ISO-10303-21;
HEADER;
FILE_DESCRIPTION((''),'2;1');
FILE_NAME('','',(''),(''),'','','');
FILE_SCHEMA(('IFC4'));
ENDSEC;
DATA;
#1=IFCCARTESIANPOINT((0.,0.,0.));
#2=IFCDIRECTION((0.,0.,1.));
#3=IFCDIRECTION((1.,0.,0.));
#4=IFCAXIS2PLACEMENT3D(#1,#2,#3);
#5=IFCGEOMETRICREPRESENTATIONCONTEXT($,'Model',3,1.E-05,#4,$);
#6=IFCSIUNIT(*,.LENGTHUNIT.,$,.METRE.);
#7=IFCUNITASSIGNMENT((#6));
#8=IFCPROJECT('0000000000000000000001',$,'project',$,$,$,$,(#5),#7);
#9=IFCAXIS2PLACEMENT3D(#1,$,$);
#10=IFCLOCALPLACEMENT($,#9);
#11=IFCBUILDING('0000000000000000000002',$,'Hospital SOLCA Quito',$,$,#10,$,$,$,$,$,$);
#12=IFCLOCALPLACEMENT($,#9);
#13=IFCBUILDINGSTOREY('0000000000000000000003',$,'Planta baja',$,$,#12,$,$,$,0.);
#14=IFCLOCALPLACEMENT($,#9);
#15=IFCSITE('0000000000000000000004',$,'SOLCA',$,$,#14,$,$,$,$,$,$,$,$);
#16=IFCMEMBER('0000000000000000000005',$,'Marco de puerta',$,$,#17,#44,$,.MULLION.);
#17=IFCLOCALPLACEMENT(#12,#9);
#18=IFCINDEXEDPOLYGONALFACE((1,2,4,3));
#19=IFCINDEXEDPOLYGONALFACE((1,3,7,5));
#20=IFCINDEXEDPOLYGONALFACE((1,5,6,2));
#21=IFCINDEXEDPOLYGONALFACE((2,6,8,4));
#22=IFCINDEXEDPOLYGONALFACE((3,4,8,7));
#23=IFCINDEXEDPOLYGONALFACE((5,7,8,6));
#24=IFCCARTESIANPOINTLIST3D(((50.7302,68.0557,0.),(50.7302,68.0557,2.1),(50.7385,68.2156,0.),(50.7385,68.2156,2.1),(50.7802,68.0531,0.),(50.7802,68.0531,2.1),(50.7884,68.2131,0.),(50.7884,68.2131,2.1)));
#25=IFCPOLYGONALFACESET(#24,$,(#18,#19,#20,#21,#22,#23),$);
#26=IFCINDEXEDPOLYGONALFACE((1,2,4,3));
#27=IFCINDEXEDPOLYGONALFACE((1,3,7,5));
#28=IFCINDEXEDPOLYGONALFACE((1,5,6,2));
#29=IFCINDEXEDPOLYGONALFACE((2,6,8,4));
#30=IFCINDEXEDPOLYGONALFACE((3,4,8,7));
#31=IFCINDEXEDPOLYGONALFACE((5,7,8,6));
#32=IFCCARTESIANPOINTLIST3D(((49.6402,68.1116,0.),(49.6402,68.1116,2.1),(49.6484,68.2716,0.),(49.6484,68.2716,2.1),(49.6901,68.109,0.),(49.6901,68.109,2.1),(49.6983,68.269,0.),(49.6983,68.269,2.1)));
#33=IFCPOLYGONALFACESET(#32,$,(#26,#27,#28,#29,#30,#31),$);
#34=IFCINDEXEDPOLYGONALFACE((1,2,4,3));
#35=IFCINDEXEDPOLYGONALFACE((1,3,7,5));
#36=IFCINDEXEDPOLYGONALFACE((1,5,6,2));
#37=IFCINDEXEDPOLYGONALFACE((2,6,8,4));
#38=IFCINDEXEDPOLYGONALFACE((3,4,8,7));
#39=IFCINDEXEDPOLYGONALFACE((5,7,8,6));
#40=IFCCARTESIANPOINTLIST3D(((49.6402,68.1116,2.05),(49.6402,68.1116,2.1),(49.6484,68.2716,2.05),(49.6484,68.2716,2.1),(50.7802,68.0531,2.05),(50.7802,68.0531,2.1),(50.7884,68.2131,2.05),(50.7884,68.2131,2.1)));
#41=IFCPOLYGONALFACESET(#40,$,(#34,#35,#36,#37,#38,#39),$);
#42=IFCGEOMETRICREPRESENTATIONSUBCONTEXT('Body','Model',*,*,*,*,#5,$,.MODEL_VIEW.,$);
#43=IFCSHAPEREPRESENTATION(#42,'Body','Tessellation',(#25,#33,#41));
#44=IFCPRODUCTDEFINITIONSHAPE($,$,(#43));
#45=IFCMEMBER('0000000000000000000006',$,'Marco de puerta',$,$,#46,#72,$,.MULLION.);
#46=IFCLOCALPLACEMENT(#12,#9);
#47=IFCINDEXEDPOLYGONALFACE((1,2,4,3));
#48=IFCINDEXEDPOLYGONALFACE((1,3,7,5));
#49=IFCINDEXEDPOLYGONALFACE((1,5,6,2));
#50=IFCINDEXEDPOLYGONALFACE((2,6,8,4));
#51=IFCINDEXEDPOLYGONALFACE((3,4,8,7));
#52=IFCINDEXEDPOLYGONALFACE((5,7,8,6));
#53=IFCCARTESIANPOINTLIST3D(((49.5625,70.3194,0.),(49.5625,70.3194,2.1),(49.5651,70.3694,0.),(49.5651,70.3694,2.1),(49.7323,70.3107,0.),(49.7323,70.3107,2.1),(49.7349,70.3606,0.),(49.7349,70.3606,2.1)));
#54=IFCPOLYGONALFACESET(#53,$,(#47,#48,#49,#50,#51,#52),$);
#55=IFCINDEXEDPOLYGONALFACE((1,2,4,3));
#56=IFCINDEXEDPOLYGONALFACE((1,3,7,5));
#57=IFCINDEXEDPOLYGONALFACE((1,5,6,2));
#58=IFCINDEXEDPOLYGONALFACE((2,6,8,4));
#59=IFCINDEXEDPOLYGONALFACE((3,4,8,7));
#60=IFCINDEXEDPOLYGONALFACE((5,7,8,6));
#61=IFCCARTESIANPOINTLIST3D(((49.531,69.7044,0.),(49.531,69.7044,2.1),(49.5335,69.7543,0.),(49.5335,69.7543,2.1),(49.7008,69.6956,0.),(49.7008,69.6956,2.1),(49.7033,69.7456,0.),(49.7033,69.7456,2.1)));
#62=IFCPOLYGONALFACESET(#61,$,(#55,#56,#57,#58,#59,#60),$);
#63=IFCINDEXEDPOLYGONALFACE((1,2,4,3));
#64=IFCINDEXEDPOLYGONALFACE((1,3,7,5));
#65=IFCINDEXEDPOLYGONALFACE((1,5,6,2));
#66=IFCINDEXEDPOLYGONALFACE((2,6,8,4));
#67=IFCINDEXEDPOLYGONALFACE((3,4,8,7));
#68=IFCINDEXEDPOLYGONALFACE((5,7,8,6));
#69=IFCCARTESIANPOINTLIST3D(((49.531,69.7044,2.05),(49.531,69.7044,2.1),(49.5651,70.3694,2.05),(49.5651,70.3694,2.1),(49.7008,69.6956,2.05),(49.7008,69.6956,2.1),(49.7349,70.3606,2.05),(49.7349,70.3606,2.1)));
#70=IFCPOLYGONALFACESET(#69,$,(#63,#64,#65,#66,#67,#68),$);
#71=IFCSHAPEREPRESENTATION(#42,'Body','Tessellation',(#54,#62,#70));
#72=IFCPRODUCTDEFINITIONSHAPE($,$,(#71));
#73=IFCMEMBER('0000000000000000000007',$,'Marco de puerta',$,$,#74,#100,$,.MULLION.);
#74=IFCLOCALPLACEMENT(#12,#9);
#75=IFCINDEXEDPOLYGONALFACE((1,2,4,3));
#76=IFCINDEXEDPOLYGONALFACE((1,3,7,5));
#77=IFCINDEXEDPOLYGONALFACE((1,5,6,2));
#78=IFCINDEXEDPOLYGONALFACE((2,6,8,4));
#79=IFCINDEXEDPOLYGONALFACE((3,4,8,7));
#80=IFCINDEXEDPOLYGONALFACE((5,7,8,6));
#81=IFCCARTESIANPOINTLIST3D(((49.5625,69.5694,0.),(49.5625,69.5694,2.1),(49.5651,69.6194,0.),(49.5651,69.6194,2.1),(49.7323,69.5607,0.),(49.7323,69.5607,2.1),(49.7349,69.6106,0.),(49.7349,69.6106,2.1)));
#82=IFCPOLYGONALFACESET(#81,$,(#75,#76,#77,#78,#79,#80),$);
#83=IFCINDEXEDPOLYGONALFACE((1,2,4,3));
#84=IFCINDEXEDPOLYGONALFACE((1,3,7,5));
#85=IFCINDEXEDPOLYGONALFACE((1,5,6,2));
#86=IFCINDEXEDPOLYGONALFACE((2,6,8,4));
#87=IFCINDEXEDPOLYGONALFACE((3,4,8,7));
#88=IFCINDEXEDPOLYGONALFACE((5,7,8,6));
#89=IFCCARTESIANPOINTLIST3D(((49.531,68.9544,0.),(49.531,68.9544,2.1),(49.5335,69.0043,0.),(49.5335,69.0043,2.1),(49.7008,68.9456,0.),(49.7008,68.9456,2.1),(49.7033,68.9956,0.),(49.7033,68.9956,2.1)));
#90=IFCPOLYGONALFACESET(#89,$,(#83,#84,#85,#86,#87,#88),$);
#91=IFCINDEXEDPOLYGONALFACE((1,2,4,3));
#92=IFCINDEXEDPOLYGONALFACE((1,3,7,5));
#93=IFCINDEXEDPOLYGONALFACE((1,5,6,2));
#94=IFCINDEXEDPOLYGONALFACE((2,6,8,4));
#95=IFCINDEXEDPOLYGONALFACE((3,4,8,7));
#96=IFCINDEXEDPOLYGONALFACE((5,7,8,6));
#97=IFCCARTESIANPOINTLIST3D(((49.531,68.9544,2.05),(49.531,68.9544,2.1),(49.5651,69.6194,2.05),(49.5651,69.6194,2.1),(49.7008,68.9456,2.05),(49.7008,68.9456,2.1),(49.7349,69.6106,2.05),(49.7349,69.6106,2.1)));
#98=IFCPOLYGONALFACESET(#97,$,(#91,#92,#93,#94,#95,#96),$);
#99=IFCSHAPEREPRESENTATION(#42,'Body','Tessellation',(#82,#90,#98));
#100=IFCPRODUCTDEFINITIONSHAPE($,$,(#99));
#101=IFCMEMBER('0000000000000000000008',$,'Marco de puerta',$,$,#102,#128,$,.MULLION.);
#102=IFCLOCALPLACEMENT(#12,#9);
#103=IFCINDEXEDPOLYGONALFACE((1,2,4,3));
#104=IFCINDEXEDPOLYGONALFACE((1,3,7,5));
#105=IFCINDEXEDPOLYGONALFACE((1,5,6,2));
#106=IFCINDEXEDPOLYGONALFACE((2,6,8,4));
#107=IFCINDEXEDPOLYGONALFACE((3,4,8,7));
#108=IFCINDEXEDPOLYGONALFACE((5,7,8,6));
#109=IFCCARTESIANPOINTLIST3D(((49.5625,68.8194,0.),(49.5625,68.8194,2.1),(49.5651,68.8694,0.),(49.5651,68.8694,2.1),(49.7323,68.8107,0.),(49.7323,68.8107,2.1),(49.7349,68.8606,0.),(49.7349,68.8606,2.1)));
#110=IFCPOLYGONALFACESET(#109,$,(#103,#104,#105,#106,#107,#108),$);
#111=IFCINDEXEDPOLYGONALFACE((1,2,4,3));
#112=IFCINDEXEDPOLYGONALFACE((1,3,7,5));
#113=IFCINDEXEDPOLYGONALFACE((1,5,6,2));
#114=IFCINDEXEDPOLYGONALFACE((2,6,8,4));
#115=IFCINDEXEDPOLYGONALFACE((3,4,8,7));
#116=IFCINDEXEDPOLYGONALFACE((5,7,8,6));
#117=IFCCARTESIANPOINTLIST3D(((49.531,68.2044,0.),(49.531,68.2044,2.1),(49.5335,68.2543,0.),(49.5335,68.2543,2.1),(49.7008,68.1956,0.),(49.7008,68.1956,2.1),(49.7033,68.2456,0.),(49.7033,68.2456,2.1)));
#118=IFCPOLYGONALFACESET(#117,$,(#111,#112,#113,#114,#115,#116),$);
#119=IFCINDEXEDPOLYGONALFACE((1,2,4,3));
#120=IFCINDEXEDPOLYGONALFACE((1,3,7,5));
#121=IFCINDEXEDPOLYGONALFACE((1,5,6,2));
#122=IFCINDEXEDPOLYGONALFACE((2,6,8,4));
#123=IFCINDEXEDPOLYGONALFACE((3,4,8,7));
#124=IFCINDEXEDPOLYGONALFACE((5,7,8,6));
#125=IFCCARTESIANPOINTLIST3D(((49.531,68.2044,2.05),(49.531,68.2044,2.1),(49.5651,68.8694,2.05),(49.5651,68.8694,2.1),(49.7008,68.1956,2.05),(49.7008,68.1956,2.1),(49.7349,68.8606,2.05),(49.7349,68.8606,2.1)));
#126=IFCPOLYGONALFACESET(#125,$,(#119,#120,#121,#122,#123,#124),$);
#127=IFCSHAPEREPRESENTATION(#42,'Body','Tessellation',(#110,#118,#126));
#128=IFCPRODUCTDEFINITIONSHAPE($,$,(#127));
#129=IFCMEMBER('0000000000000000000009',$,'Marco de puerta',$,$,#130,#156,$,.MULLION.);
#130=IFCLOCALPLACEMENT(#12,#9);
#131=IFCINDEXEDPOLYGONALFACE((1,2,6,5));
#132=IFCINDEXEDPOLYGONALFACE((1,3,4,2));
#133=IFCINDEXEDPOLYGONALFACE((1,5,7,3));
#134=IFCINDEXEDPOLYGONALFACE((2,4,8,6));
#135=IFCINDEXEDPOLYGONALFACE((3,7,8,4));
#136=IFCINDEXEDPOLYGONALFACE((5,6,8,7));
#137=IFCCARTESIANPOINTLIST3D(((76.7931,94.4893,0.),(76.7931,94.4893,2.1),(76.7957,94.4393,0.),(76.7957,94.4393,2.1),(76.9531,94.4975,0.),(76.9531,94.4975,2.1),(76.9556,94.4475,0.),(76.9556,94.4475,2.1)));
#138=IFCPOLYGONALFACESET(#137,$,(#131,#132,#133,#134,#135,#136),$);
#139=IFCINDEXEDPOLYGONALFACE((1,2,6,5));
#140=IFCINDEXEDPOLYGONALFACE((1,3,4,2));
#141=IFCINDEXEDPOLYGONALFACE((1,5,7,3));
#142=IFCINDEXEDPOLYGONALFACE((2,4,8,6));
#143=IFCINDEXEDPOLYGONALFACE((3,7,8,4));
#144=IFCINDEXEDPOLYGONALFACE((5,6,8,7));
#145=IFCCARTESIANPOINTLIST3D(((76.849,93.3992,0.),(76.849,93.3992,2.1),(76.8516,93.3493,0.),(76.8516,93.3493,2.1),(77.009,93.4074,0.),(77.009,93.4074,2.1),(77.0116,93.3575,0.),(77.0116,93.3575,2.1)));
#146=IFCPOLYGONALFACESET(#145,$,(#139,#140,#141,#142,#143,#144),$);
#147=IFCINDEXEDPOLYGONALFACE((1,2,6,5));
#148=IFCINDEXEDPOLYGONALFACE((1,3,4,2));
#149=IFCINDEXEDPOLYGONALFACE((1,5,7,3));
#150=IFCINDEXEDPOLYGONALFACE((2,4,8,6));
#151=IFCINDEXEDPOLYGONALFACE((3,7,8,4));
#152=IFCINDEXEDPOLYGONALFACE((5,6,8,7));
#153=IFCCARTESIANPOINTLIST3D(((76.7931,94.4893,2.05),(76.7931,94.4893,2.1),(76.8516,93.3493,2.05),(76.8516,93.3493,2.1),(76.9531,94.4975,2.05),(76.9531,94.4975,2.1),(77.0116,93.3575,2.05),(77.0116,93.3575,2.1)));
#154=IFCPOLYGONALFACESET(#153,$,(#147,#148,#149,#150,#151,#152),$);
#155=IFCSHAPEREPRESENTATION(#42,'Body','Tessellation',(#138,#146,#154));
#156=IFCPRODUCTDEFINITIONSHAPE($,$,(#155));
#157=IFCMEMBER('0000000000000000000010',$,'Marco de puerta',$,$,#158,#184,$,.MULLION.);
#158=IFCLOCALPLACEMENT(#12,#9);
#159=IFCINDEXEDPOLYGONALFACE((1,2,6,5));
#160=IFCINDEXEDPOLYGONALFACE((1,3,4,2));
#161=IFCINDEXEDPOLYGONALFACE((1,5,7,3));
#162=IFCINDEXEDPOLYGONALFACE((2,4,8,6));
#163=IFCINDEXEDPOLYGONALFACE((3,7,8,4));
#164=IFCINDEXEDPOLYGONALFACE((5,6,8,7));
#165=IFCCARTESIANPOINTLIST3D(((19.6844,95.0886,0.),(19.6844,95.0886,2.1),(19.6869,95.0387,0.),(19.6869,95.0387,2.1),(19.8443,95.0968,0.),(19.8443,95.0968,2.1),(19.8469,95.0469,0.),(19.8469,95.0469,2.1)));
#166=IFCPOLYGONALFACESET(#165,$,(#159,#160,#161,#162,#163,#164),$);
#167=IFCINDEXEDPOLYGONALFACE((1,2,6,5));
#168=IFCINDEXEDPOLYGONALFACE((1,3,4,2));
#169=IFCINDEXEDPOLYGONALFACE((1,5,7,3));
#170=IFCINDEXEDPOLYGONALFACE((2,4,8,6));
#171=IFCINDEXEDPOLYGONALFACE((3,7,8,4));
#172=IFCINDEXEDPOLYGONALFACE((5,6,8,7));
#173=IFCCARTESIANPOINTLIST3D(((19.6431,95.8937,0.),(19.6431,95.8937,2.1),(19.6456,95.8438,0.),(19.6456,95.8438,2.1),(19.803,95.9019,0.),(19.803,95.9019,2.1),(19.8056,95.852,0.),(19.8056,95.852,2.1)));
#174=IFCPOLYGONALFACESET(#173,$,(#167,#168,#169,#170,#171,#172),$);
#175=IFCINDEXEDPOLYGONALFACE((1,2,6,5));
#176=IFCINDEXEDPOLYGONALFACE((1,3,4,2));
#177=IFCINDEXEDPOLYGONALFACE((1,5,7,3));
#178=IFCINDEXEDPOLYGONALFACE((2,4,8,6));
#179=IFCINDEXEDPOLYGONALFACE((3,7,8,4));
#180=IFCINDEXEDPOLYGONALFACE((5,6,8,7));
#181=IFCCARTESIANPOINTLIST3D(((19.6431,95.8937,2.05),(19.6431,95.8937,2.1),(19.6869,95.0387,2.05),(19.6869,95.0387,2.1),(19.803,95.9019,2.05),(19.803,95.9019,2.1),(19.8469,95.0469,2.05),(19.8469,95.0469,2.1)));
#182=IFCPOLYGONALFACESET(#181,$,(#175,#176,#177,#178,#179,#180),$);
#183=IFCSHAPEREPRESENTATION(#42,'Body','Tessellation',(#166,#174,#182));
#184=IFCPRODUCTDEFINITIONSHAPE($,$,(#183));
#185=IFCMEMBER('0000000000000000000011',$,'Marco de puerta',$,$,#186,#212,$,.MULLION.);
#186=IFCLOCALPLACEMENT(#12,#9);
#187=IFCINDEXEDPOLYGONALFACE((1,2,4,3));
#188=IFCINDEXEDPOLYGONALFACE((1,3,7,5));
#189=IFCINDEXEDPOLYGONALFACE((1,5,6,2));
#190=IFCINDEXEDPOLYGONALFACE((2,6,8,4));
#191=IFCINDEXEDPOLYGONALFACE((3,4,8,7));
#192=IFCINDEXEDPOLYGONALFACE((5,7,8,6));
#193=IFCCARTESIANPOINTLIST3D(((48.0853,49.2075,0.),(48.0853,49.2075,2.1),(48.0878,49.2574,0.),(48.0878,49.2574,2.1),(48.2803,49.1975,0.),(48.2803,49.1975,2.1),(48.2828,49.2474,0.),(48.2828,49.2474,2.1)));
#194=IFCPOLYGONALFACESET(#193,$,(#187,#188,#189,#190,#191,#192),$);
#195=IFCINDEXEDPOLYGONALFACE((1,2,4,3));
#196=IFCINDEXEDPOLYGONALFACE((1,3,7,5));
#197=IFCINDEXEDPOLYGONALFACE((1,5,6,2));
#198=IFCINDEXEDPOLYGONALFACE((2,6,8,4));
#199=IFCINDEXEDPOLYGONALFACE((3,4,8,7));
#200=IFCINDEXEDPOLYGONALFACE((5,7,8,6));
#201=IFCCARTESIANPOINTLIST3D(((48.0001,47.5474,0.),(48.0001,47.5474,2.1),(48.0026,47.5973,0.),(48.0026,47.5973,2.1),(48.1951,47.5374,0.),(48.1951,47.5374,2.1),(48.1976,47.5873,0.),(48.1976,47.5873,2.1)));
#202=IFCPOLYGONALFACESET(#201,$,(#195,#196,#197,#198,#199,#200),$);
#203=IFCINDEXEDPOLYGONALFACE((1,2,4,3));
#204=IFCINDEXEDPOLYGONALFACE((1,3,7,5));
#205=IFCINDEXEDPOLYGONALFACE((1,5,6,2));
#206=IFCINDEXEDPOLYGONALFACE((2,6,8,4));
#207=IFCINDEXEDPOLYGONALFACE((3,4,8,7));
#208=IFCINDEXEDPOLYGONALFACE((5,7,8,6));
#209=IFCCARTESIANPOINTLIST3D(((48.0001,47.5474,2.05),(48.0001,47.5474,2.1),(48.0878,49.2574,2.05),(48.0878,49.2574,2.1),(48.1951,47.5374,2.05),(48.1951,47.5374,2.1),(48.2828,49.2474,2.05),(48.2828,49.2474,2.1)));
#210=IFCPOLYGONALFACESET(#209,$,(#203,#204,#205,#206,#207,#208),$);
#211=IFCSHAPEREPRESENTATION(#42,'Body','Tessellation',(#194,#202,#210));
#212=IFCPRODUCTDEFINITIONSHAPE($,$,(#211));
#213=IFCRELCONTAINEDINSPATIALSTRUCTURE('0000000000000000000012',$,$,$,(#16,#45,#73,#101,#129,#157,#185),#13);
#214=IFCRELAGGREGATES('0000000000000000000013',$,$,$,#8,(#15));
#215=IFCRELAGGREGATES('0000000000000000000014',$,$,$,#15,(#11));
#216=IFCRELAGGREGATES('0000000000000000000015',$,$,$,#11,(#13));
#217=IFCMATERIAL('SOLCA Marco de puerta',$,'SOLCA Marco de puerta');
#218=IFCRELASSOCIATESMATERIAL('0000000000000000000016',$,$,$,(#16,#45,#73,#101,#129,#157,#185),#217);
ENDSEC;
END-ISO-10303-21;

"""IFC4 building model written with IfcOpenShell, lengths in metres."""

from ifc_helpers import new_model, si_unit, frame, origin, origin_with_axes, place, context, subcontext, project, spatial, polyline, outline, extrude, material, element, save


model = new_model("IFC4")

# Units and contexts
model_context = context("Model", 3, precision=1e-05, world=origin_with_axes())
body_context = subcontext(model_context, "Body", "Model", "MODEL_VIEW")
ifc_project = project(units=[si_unit("LENGTHUNIT", "METRE")], contexts=[model_context])

# Site, building, storey
site_placement = place(None, origin())
site = spatial("IfcSite", under=ifc_project, at=site_placement, Name="SOLCA")
building_placement = place(None, origin())
building = spatial("IfcBuilding", under=site, at=building_placement, Name="Hospital SOLCA Quito")
storey_placement = place(None, origin())
storey = spatial("IfcBuildingStorey", under=building, at=storey_placement, Name="Planta baja", Elevation=0.0)

# Members
ifc_material_1 = material(Name="SOLCA Marco de puerta", Category="SOLCA Marco de puerta")
member_1_placement = place(storey_placement, origin_with_axes())
element("IfcMember", 1, at=member_1_placement, inside=storey, material=ifc_material_1, Name="Marco de puerta", PredefinedType="MULLION", context=body_context, shape_type="SweptSolid", body=[
    extrude(outline(polyline([(50.7884, 68.2131), (50.7385, 68.2156), (50.7302, 68.0557), (50.7802, 68.0531), (50.7884, 68.2131)])), origin_with_axes(), (0.0, 0.0, 1.0), 2.1),
    extrude(outline(polyline([(49.6983, 68.269), (49.6484, 68.2716), (49.6402, 68.1116), (49.6901, 68.109), (49.6983, 68.269)])), origin_with_axes(), (0.0, 0.0, 1.0), 2.1),
    extrude(outline(polyline([(50.7884, 68.2131), (49.6484, 68.2716), (49.6402, 68.1116), (50.7802, 68.0531), (50.7884, 68.2131)])), frame((0.0, 0.0, 2.05), z_axis=(0.0, 0.0, 1.0), x_axis=(1.0, 0.0, 0.0)), (0.0, 0.0, 1.0), 0.05),
])
member_2_placement = place(storey_placement, origin_with_axes())
element("IfcMember", 2, at=member_2_placement, inside=storey, material=ifc_material_1, Name="Marco de puerta", PredefinedType="MULLION", context=body_context, shape_type="SweptSolid", body=[
    extrude(outline(polyline([(49.5651, 70.3694), (49.5625, 70.3194), (49.7323, 70.3107), (49.7349, 70.3606), (49.5651, 70.3694)])), origin_with_axes(), (0.0, 0.0, 1.0), 2.1),
    extrude(outline(polyline([(49.5335, 69.7543), (49.531, 69.7044), (49.7008, 69.6956), (49.7033, 69.7456), (49.5335, 69.7543)])), origin_with_axes(), (0.0, 0.0, 1.0), 2.1),
    extrude(outline(polyline([(49.5651, 70.3694), (49.531, 69.7044), (49.7008, 69.6956), (49.7349, 70.3606), (49.5651, 70.3694)])), frame((0.0, 0.0, 2.05), z_axis=(0.0, 0.0, 1.0), x_axis=(1.0, 0.0, 0.0)), (0.0, 0.0, 1.0), 0.05),
])
member_3_placement = place(storey_placement, origin_with_axes())
element("IfcMember", 3, at=member_3_placement, inside=storey, material=ifc_material_1, Name="Marco de puerta", PredefinedType="MULLION", context=body_context, shape_type="SweptSolid", body=[
    extrude(outline(polyline([(49.5651, 69.6194), (49.5625, 69.5694), (49.7323, 69.5607), (49.7349, 69.6106), (49.5651, 69.6194)])), origin_with_axes(), (0.0, 0.0, 1.0), 2.1),
    extrude(outline(polyline([(49.5335, 69.0043), (49.531, 68.9544), (49.7008, 68.9456), (49.7033, 68.9956), (49.5335, 69.0043)])), origin_with_axes(), (0.0, 0.0, 1.0), 2.1),
    extrude(outline(polyline([(49.5651, 69.6194), (49.531, 68.9544), (49.7008, 68.9456), (49.7349, 69.6106), (49.5651, 69.6194)])), frame((0.0, 0.0, 2.05), z_axis=(0.0, 0.0, 1.0), x_axis=(1.0, 0.0, 0.0)), (0.0, 0.0, 1.0), 0.05),
])
member_4_placement = place(storey_placement, origin_with_axes())
element("IfcMember", 4, at=member_4_placement, inside=storey, material=ifc_material_1, Name="Marco de puerta", PredefinedType="MULLION", context=body_context, shape_type="SweptSolid", body=[
    extrude(outline(polyline([(49.5651, 68.8694), (49.5625, 68.8194), (49.7323, 68.8107), (49.7349, 68.8606), (49.5651, 68.8694)])), origin_with_axes(), (0.0, 0.0, 1.0), 2.1),
    extrude(outline(polyline([(49.5335, 68.2543), (49.531, 68.2044), (49.7008, 68.1956), (49.7033, 68.2456), (49.5335, 68.2543)])), origin_with_axes(), (0.0, 0.0, 1.0), 2.1),
    extrude(outline(polyline([(49.5651, 68.8694), (49.531, 68.2044), (49.7008, 68.1956), (49.7349, 68.8606), (49.5651, 68.8694)])), frame((0.0, 0.0, 2.05), z_axis=(0.0, 0.0, 1.0), x_axis=(1.0, 0.0, 0.0)), (0.0, 0.0, 1.0), 0.05),
])
member_5_placement = place(storey_placement, origin_with_axes())
element("IfcMember", 5, at=member_5_placement, inside=storey, material=ifc_material_1, Name="Marco de puerta", PredefinedType="MULLION", context=body_context, shape_type="SweptSolid", body=[
    extrude(outline(polyline([(76.7931, 94.4893), (76.7957, 94.4393), (76.9556, 94.4475), (76.9531, 94.4975), (76.7931, 94.4893)])), origin_with_axes(), (0.0, 0.0, 1.0), 2.1),
    extrude(outline(polyline([(76.849, 93.3992), (76.8516, 93.3493), (77.0116, 93.3575), (77.009, 93.4074), (76.849, 93.3992)])), origin_with_axes(), (0.0, 0.0, 1.0), 2.1),
    extrude(outline(polyline([(76.7931, 94.4893), (76.8516, 93.3493), (77.0116, 93.3575), (76.9531, 94.4975), (76.7931, 94.4893)])), frame((0.0, 0.0, 2.05), z_axis=(0.0, 0.0, 1.0), x_axis=(1.0, 0.0, 0.0)), (0.0, 0.0, 1.0), 0.05),
])
member_6_placement = place(storey_placement, origin_with_axes())
element("IfcMember", 6, at=member_6_placement, inside=storey, material=ifc_material_1, Name="Marco de puerta", PredefinedType="MULLION", context=body_context, shape_type="SweptSolid", body=[
    extrude(outline(polyline([(19.8469, 95.0469), (19.8443, 95.0968), (19.6844, 95.0886), (19.6869, 95.0387), (19.8469, 95.0469)])), origin_with_axes(), (0.0, 0.0, 1.0), 2.1),
    extrude(outline(polyline([(19.8056, 95.852), (19.803, 95.9019), (19.6431, 95.8937), (19.6456, 95.8438), (19.8056, 95.852)])), origin_with_axes(), (0.0, 0.0, 1.0), 2.1),
    extrude(outline(polyline([(19.8469, 95.0469), (19.803, 95.9019), (19.6431, 95.8937), (19.6869, 95.0387), (19.8469, 95.0469)])), frame((0.0, 0.0, 2.05), z_axis=(0.0, 0.0, 1.0), x_axis=(1.0, 0.0, 0.0)), (0.0, 0.0, 1.0), 0.05),
])
member_7_placement = place(storey_placement, origin_with_axes())
element("IfcMember", 7, at=member_7_placement, inside=storey, material=ifc_material_1, Name="Marco de puerta", PredefinedType="MULLION", context=body_context, shape_type="SweptSolid", body=[
    extrude(outline(polyline([(48.0878, 49.2574), (48.0853, 49.2075), (48.2803, 49.1975), (48.2828, 49.2474), (48.0878, 49.2574)])), origin_with_axes(), (0.0, 0.0, 1.0), 2.1),
    extrude(outline(polyline([(48.0026, 47.5973), (48.0001, 47.5474), (48.1951, 47.5374), (48.1976, 47.5873), (48.0026, 47.5973)])), origin_with_axes(), (0.0, 0.0, 1.0), 2.1),
    extrude(outline(polyline([(48.0878, 49.2574), (48.0001, 47.5474), (48.1951, 47.5374), (48.2828, 49.2474), (48.0878, 49.2574)])), frame((0.0, 0.0, 2.05), z_axis=(0.0, 0.0, 1.0), x_axis=(1.0, 0.0, 0.0)), (0.0, 0.0, 1.0), 0.05),
])

save(model, "model.ifc")
